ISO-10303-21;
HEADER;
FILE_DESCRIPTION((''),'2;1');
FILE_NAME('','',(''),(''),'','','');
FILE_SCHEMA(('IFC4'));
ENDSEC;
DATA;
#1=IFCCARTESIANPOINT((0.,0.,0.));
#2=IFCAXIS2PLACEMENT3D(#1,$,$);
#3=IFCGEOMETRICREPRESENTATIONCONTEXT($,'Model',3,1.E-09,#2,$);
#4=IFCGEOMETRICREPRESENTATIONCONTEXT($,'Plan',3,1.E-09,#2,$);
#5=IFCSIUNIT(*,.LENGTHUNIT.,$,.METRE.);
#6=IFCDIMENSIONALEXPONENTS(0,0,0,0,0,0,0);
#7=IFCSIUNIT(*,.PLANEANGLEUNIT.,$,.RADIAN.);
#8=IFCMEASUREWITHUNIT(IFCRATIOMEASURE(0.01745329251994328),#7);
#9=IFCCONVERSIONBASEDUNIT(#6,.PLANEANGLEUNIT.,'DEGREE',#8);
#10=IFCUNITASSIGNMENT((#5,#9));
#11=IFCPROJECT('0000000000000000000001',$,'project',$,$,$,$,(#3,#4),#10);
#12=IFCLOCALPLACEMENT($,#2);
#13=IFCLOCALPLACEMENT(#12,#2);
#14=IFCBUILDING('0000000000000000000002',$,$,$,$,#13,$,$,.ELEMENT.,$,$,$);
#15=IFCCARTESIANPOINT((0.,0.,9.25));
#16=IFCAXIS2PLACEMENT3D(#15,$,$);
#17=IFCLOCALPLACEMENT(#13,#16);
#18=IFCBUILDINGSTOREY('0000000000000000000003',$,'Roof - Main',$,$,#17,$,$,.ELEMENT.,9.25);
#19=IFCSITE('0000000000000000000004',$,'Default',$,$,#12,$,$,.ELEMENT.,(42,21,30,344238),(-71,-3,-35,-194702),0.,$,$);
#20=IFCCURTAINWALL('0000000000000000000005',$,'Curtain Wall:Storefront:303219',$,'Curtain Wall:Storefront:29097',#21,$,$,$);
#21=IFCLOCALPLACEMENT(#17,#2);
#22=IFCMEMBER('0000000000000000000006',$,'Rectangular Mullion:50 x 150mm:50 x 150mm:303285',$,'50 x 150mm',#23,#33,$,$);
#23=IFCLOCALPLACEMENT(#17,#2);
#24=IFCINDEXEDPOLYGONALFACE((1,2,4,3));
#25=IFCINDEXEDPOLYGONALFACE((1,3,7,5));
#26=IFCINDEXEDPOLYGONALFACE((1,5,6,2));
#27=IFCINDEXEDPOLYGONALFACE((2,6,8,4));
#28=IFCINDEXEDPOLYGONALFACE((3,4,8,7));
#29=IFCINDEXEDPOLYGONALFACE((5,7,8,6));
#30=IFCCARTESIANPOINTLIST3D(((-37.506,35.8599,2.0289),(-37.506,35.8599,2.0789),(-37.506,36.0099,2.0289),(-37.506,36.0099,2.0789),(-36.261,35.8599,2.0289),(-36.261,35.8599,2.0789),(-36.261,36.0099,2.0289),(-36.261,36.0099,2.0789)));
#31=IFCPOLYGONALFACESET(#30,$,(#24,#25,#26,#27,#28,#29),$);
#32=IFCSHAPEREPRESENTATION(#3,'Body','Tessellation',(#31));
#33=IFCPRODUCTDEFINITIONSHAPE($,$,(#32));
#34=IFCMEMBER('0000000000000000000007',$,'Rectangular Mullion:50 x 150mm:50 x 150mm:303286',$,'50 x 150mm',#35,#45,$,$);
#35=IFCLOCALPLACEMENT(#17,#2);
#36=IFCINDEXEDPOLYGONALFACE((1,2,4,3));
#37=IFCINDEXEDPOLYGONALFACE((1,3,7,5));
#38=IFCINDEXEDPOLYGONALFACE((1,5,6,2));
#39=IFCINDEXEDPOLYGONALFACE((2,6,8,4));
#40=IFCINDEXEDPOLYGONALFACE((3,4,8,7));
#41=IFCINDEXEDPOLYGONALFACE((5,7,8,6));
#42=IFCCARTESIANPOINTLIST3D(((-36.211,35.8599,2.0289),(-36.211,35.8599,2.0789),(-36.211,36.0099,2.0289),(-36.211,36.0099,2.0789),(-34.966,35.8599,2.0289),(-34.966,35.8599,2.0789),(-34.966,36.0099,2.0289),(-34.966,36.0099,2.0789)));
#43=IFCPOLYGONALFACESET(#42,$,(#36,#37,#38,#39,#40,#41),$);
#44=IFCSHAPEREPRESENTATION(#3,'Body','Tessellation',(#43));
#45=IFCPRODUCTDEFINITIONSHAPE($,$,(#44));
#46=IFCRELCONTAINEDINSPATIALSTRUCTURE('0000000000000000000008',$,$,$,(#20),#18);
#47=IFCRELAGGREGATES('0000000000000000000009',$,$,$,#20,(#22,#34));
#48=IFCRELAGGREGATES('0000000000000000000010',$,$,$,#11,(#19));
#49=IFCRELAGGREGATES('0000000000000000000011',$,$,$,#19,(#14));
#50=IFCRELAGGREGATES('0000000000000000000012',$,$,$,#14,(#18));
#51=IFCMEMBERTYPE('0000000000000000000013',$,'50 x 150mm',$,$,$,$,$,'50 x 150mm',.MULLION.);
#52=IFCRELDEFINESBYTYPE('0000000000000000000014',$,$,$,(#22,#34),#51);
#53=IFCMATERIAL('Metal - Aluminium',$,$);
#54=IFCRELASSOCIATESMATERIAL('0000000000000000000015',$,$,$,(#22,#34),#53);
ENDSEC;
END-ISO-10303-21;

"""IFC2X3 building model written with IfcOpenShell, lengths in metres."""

from ifc_helpers import new_model, entity, si_unit, converted_unit, frame, origin, origin_2d_with_axis, place, context, project, spatial, rectangle, extrude, source, transform, mapped, material, type_object, type_shapes, element, aggregate, save


model = new_model("IFC2X3")

# Units and contexts
model_context = context("Model", 3, precision=1e-09, world=origin())
plan_context = context("Plan", 3, precision=1e-09, world=origin())
ifc_project = project(units=[si_unit("LENGTHUNIT", "METRE"), converted_unit("PLANEANGLEUNIT", "DEGREE", entity("IfcRatioMeasure", 0.01745329251994328), si_unit("PLANEANGLEUNIT", "RADIAN"), dimensions=[0, 0, 0, 0, 0, 0, 0])], contexts=[model_context, plan_context])

# Site, building, storey
site_placement = place(None, origin())
site = spatial("IfcSite", under=ifc_project, at=site_placement, Name="Default", CompositionType="ELEMENT", RefLatitude=(42, 21, 30, 344238), RefLongitude=(-71, -3, -35, -194702), RefElevation=0.0)
building_placement = place(site_placement, origin())
building = spatial("IfcBuilding", under=site, at=building_placement, CompositionType="ELEMENT")
storey_placement = place(building_placement, frame((0.0, 0.0, 9.25)))
storey = spatial("IfcBuildingStorey", under=building, at=storey_placement, Name="Roof - Main", CompositionType="ELEMENT", Elevation=9.25)

# Curtain wall, members
curtain_wall_placement = place(storey_placement, origin())
curtain_wall = element("IfcCurtainWall", 1, at=curtain_wall_placement, inside=storey, Name="Curtain Wall:Storefront:303219", ObjectType="Curtain Wall:Storefront:29097")
ifc_material_1 = material(Name="Metal - Aluminium")
member_type_1 = type_object("IfcMemberType", Name="50 x 150mm", ElementType="50 x 150mm", PredefinedType="MULLION")
shared_shape_1 = source(origin(), model_context, "Body", "SweptSolid", [
    extrude(rectangle(XDim=0.05, YDim=0.15, at=origin_2d_with_axis()), frame((0.0, 0.0, -1.245), z_axis=(0.0, 0.0, 1.0), x_axis=(-1.0, 0.0, 0.0)), (0.0, 0.0, 1.0), 1.245),
])
type_shapes(member_type_1, [shared_shape_1])
member_1_placement = place(storey_placement, frame((-36.261, 35.9349, 2.0539), z_axis=(1.0, 0.0, 0.0), x_axis=(0.0, 0.0, 1.0)))
member_1 = element("IfcMember", 2, at=member_1_placement, type_object=member_type_1, material=ifc_material_1, Name="Rectangular Mullion:50 x 150mm:50 x 150mm:303285", ObjectType="50 x 150mm", context=model_context, shape_type="MappedRepresentation", body=[
    mapped(shared_shape_1, transform((0.0, 0.0, 0.0), scale=1.0)),
])
member_2_placement = place(storey_placement, frame((-34.966, 35.9349, 2.0539), z_axis=(1.0, 0.0, 0.0), x_axis=(0.0, 0.0, 1.0)))
member_2 = element("IfcMember", 3, at=member_2_placement, type_object=member_type_1, material=ifc_material_1, Name="Rectangular Mullion:50 x 150mm:50 x 150mm:303286", ObjectType="50 x 150mm", context=model_context, shape_type="MappedRepresentation", body=[
    mapped(shared_shape_1, transform((0.0, 0.0, 0.0), scale=1.0)),
])
aggregate(curtain_wall, [member_1, member_2])

save(model, "model.ifc")
